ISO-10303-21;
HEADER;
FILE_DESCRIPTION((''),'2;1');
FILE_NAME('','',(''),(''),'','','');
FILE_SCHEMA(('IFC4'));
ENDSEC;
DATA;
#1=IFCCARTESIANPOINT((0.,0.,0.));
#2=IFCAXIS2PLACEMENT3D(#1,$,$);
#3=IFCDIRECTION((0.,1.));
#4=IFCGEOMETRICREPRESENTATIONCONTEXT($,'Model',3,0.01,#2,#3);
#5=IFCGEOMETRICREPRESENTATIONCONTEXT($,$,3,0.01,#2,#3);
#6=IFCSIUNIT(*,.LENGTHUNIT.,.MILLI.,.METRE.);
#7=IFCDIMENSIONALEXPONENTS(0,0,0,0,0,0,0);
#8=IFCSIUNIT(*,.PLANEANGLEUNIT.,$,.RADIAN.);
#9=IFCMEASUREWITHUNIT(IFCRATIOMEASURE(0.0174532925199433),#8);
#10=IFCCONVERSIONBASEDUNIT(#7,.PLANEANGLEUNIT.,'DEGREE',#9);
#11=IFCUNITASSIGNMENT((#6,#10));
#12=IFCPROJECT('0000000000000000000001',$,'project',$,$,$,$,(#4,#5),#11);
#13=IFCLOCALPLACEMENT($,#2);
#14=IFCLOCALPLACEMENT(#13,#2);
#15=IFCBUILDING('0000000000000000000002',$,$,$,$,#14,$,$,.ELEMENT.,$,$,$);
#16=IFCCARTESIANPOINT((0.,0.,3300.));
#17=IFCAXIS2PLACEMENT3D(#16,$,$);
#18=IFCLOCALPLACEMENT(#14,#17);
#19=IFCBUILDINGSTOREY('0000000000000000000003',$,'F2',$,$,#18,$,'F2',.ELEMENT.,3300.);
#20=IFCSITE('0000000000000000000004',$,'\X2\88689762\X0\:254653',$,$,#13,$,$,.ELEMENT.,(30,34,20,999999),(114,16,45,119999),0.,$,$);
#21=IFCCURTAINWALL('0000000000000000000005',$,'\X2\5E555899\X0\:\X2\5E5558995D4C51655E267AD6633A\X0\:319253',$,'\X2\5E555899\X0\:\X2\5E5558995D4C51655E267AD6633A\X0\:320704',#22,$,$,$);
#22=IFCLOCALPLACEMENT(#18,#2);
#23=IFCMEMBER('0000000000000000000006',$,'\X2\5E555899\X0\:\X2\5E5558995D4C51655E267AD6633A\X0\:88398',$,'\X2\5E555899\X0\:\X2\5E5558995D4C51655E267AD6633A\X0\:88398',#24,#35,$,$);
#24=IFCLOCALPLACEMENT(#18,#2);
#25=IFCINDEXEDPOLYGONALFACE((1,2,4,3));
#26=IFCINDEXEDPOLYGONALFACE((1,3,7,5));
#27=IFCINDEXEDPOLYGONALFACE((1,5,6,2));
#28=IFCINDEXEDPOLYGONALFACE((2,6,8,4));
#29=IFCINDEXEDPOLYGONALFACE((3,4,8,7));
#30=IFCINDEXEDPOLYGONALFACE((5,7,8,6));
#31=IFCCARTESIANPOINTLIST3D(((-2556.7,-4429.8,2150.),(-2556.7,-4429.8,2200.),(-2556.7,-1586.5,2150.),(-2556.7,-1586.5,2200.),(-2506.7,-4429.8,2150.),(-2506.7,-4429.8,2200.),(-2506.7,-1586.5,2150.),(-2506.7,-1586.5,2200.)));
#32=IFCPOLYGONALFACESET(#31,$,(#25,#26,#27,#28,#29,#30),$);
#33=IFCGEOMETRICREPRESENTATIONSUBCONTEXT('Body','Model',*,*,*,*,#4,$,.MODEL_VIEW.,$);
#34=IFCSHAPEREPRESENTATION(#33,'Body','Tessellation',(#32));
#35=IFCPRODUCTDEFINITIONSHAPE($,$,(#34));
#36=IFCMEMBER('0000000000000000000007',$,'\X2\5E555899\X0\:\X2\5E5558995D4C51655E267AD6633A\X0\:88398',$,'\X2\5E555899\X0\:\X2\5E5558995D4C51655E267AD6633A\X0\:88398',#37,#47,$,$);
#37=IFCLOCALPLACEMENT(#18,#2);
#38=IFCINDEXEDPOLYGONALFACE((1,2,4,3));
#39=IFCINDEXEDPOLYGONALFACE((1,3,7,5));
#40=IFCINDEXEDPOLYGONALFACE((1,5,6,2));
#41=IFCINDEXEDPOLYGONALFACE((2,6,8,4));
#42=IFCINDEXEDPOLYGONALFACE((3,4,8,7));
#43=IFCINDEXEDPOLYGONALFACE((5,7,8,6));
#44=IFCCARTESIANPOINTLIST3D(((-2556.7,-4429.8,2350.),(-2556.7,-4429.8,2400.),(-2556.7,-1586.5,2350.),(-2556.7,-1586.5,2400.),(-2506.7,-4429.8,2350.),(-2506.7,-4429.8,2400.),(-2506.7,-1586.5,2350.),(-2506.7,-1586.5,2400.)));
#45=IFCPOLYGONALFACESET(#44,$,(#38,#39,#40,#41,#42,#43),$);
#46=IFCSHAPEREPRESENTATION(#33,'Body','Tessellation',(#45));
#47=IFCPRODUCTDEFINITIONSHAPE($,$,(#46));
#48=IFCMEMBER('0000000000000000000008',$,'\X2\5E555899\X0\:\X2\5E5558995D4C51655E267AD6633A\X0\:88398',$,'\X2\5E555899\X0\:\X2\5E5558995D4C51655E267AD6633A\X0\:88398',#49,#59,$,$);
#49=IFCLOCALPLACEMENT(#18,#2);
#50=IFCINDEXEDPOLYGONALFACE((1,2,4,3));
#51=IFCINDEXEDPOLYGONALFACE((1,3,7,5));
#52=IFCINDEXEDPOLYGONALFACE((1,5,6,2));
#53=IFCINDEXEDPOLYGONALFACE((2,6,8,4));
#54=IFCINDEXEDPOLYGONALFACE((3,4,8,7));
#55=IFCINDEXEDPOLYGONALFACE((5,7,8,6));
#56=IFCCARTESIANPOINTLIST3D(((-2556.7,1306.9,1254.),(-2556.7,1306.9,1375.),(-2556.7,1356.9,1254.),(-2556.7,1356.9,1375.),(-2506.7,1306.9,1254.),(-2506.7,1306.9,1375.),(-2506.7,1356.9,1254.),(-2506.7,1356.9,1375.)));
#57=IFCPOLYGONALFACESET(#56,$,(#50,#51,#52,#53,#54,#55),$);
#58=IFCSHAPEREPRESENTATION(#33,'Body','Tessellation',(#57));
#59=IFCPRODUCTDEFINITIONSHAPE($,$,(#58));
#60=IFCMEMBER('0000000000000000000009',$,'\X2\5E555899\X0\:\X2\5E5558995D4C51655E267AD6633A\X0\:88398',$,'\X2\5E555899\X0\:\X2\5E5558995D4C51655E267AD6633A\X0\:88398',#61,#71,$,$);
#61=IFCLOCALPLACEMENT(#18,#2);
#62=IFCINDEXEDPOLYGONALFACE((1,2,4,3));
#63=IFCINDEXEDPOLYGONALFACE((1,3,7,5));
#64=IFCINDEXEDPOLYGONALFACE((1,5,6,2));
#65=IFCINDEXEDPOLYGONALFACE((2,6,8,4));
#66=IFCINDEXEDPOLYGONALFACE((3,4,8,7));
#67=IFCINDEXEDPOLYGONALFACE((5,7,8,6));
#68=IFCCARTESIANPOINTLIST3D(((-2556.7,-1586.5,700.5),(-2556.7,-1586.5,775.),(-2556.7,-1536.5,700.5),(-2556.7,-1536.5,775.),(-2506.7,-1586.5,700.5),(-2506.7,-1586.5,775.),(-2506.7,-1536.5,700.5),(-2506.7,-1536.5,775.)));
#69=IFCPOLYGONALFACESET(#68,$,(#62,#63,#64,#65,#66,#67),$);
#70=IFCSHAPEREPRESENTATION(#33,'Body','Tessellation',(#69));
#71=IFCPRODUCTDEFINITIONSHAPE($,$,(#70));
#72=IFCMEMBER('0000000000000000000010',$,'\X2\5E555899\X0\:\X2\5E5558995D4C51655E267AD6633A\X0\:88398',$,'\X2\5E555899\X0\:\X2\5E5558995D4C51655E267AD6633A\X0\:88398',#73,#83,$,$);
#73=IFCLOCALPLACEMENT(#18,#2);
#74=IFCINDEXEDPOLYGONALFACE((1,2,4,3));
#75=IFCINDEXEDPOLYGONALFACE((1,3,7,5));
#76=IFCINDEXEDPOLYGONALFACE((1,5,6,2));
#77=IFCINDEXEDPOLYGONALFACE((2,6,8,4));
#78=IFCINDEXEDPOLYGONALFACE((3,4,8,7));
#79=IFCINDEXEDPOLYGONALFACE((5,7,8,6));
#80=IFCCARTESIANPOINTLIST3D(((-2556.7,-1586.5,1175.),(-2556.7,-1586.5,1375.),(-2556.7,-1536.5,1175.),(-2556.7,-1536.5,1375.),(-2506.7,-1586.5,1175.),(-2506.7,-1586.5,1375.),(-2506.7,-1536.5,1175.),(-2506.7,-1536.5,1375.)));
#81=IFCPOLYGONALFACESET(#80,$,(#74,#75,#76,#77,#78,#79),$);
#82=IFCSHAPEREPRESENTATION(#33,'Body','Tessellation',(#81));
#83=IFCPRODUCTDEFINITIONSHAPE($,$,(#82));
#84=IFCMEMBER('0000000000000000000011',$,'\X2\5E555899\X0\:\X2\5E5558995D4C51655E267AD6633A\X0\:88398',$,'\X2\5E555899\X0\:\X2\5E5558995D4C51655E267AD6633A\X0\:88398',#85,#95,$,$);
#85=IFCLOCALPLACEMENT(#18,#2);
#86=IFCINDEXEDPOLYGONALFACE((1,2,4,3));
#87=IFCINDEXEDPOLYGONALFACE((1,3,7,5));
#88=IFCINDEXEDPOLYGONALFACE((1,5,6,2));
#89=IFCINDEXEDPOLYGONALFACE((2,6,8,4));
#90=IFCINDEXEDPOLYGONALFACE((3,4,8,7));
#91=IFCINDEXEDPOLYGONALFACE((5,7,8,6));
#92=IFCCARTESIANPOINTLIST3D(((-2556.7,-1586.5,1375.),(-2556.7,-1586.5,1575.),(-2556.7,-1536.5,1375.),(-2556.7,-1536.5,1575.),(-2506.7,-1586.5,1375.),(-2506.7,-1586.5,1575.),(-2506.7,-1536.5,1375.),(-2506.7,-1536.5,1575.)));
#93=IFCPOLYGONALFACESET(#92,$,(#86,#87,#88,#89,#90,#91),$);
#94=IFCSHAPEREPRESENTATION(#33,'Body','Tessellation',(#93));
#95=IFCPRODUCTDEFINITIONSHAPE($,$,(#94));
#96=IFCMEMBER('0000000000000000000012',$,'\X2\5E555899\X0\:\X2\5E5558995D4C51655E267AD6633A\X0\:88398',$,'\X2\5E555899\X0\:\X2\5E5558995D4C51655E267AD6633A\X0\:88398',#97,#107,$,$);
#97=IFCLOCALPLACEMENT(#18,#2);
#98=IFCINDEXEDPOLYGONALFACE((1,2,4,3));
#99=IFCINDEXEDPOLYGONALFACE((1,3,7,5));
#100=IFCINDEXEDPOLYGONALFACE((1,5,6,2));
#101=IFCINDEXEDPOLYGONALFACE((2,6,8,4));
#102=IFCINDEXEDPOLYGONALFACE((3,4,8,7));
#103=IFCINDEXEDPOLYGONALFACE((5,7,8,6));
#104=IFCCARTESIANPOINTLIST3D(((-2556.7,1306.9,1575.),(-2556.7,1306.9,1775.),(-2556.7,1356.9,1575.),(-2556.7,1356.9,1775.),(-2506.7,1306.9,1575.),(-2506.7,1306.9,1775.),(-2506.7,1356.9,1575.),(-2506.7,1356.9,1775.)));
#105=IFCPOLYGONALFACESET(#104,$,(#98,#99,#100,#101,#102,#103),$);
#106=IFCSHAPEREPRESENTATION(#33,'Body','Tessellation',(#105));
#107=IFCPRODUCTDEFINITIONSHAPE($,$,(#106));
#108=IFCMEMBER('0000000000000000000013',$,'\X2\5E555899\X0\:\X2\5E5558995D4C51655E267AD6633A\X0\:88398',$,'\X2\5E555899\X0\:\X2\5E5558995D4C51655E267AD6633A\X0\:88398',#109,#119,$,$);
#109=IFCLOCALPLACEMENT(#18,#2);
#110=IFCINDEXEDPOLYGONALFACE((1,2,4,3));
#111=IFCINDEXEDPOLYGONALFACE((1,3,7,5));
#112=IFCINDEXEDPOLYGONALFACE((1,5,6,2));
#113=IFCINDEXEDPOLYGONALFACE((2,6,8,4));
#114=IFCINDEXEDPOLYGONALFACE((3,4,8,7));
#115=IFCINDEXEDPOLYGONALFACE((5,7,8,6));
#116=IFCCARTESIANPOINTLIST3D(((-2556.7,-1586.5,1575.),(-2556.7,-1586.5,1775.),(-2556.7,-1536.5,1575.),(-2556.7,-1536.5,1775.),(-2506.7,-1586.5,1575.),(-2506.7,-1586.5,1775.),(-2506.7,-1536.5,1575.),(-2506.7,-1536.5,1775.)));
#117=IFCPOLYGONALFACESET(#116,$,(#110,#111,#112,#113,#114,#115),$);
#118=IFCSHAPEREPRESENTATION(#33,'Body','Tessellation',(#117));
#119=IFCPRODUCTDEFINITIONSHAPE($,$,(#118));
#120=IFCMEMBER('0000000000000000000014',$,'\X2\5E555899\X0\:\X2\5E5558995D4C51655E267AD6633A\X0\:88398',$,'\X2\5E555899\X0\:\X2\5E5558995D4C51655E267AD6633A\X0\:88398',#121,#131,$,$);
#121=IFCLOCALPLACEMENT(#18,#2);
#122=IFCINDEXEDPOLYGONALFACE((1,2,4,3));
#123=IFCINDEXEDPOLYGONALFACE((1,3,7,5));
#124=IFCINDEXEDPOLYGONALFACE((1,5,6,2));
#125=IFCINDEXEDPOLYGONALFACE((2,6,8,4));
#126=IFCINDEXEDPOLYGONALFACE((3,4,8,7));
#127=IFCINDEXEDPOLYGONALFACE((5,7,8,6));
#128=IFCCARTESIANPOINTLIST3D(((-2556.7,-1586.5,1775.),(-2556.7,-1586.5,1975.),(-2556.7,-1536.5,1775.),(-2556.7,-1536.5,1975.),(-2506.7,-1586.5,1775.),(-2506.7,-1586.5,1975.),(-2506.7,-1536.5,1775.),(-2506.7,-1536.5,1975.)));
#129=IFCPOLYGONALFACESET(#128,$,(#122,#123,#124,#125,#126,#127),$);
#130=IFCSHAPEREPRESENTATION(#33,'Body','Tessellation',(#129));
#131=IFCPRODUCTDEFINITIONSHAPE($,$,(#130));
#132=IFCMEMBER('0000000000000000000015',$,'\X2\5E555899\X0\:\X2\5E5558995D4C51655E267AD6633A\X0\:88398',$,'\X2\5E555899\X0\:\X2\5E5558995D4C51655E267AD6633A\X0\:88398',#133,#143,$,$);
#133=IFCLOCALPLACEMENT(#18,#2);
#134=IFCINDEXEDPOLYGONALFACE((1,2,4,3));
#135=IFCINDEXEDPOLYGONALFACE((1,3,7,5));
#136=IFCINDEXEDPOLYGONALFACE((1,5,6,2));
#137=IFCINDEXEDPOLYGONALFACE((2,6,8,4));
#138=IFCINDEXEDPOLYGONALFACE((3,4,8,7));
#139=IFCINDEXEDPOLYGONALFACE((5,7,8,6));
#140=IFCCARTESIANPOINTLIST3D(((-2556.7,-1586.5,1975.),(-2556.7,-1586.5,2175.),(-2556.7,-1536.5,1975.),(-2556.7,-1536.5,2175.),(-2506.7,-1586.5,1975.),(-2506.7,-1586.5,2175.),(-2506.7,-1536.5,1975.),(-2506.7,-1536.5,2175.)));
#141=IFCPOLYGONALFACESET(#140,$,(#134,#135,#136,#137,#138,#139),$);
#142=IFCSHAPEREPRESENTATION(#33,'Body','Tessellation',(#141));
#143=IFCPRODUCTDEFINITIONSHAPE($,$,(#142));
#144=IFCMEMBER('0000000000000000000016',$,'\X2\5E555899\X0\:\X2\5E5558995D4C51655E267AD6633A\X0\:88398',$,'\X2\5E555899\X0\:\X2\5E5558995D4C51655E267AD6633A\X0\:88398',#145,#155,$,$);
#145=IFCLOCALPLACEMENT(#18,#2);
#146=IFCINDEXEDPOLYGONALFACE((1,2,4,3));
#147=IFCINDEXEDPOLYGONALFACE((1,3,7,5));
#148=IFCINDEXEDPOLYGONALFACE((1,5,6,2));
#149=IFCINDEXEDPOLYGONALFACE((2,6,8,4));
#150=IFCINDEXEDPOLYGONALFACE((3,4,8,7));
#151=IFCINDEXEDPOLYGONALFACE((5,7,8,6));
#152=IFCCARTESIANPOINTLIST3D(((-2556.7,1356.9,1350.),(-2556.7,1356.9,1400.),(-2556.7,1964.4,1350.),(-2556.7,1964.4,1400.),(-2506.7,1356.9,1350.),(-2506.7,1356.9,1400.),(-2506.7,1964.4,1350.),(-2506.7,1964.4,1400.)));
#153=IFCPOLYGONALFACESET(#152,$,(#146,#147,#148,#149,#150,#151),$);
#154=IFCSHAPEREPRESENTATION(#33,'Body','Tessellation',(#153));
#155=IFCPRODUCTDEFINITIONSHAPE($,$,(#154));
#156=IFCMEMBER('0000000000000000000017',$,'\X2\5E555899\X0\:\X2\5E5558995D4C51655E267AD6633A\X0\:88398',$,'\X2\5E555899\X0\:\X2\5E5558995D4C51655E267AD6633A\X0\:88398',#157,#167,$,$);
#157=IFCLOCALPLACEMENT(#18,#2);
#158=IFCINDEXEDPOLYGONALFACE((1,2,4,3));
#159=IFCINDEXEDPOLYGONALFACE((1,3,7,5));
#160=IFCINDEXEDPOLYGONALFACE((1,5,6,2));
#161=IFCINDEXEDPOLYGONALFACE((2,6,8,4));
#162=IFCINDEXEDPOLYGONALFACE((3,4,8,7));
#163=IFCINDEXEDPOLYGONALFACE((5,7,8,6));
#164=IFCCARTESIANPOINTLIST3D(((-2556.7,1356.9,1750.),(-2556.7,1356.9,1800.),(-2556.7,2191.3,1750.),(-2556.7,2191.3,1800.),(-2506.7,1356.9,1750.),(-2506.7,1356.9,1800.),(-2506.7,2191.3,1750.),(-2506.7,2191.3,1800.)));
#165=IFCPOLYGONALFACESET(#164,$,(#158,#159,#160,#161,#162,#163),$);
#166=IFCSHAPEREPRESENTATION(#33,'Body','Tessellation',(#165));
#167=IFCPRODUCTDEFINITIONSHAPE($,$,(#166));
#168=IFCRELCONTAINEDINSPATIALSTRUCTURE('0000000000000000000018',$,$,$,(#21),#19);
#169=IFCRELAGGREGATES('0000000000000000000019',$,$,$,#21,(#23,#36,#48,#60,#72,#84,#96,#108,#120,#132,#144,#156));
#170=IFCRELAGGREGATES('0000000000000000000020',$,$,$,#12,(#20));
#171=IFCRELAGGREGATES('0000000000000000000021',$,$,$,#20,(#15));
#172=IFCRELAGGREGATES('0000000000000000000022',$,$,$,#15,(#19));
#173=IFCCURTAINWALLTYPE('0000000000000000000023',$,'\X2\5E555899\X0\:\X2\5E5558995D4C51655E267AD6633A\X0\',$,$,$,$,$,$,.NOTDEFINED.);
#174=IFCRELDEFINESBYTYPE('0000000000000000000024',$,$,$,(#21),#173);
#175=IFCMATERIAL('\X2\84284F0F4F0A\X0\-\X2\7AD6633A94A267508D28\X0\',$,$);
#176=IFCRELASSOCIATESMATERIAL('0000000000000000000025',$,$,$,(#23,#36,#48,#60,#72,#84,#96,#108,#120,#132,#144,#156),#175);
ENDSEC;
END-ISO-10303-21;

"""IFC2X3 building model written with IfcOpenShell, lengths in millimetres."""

from ifc_helpers import new_model, entity, si_unit, converted_unit, direction, frame, origin, origin_2d_with_axis, place, context, subcontext, project, spatial, rectangle, extrude, material, type_object, element, aggregate, save


model = new_model("IFC2X3")

# Units and contexts
model_context = context("Model", 3, precision=0.01, world=origin(), true_north=direction((0.0, 1.0)))
context_of_model = context(None, 3, precision=0.01, world=origin(), true_north=direction((0.0, 1.0)))
body_context = subcontext(model_context, "Body", "Model", "MODEL_VIEW")
ifc_project = project(units=[si_unit("LENGTHUNIT", "METRE", prefix="MILLI"), converted_unit("PLANEANGLEUNIT", "DEGREE", entity("IfcRatioMeasure", 0.0174532925199433), si_unit("PLANEANGLEUNIT", "RADIAN"), dimensions=[0, 0, 0, 0, 0, 0, 0])], contexts=[model_context, context_of_model])

# Site, building, storey
site_placement = place(None, origin())
site = spatial("IfcSite", under=ifc_project, at=site_placement, Name="表面:254653", CompositionType="ELEMENT", RefLatitude=(30, 34, 20, 999999), RefLongitude=(114, 16, 45, 119999), RefElevation=0.0)
building_placement = place(site_placement, origin())
building = spatial("IfcBuilding", under=site, at=building_placement, CompositionType="ELEMENT")
storey_placement = place(building_placement, frame((0.0, 0.0, 3300.0)))
storey = spatial("IfcBuildingStorey", under=building, at=storey_placement, Name="F2", LongName="F2", CompositionType="ELEMENT", Elevation=3300.0)

# Curtain wall, members
curtain_wall_type_1 = type_object("IfcCurtainWallType", Name="幕墙:幕墙嵌入带竖挺", PredefinedType="NOTDEFINED")
curtain_wall_1_placement = place(storey_placement, frame((0.0, 0.0, -3300.0)))
curtain_wall_1 = element("IfcCurtainWall", 1, at=curtain_wall_1_placement, inside=storey, type_object=curtain_wall_type_1, Name="幕墙:幕墙嵌入带竖挺:319253", ObjectType="幕墙:幕墙嵌入带竖挺:320704")
ifc_material_1 = material(Name="萨伏伊-竖挺钢材质")
member_1_placement = place(curtain_wall_1_placement, frame((0.0, 0.0, 3300.0)))
member_1 = element("IfcMember", 2, at=member_1_placement, material=ifc_material_1, Name="幕墙:幕墙嵌入带竖挺:88398", ObjectType="幕墙:幕墙嵌入带竖挺:88398", context=body_context, shape_type="SweptSolid", body=[
    extrude(rectangle(XDim=50.0, YDim=50.0, at=origin_2d_with_axis()), frame((-2531.7, -4429.8, 2175.0), z_axis=(0.0, 1.0, 0.0), x_axis=(0.0, 0.0, -1.0)), (0.0, 0.0, 1.0), 2843.3),
])
member_2_placement = place(curtain_wall_1_placement, frame((0.0, 0.0, 3300.0)))
member_2 = element("IfcMember", 3, at=member_2_placement, material=ifc_material_1, Name="幕墙:幕墙嵌入带竖挺:88398", ObjectType="幕墙:幕墙嵌入带竖挺:88398", context=body_context, shape_type="SweptSolid", body=[
    extrude(rectangle(XDim=50.0, YDim=50.0, at=origin_2d_with_axis()), frame((-2531.7, -4429.8, 2375.0), z_axis=(0.0, 1.0, 0.0), x_axis=(0.0, 0.0, -1.0)), (0.0, 0.0, 1.0), 2843.3),
])
member_3_placement = place(curtain_wall_1_placement, frame((0.0, 0.0, 3300.0)))
member_3 = element("IfcMember", 4, at=member_3_placement, material=ifc_material_1, Name="幕墙:幕墙嵌入带竖挺:88398", ObjectType="幕墙:幕墙嵌入带竖挺:88398", context=body_context, shape_type="SweptSolid", body=[
    extrude(rectangle(XDim=50.0, YDim=50.0, at=origin_2d_with_axis()), frame((-2531.7, 1331.9, 1254.0), z_axis=(0.0, 0.0, 1.0), x_axis=(-1.0, 0.0, 0.0)), (0.0, 0.0, 1.0), 121.0),
])
member_4_placement = place(curtain_wall_1_placement, frame((0.0, 0.0, 3300.0)))
member_4 = element("IfcMember", 5, at=member_4_placement, material=ifc_material_1, Name="幕墙:幕墙嵌入带竖挺:88398", ObjectType="幕墙:幕墙嵌入带竖挺:88398", context=body_context, shape_type="SweptSolid", body=[
    extrude(rectangle(XDim=50.0, YDim=50.0, at=origin_2d_with_axis()), frame((-2531.7, -1561.5, 700.5), z_axis=(0.0, 0.0, 1.0), x_axis=(-1.0, 0.0, 0.0)), (0.0, 0.0, 1.0), 74.5),
])
member_5_placement = place(curtain_wall_1_placement, frame((0.0, 0.0, 3300.0)))
member_5 = element("IfcMember", 6, at=member_5_placement, material=ifc_material_1, Name="幕墙:幕墙嵌入带竖挺:88398", ObjectType="幕墙:幕墙嵌入带竖挺:88398", context=body_context, shape_type="SweptSolid", body=[
    extrude(rectangle(XDim=50.0, YDim=50.0, at=origin_2d_with_axis()), frame((-2531.7, -1561.5, 1175.0), z_axis=(0.0, 0.0, 1.0), x_axis=(-1.0, 0.0, 0.0)), (0.0, 0.0, 1.0), 200.0),
])
member_6_placement = place(curtain_wall_1_placement, frame((0.0, 0.0, 3300.0)))
member_6 = element("IfcMember", 7, at=member_6_placement, material=ifc_material_1, Name="幕墙:幕墙嵌入带竖挺:88398", ObjectType="幕墙:幕墙嵌入带竖挺:88398", context=body_context, shape_type="SweptSolid", body=[
    extrude(rectangle(XDim=50.0, YDim=50.0, at=origin_2d_with_axis()), frame((-2531.7, -1561.5, 1375.0), z_axis=(0.0, 0.0, 1.0), x_axis=(-1.0, 0.0, 0.0)), (0.0, 0.0, 1.0), 200.0),
])
member_7_placement = place(curtain_wall_1_placement, frame((0.0, 0.0, 3300.0)))
member_7 = element("IfcMember", 8, at=member_7_placement, material=ifc_material_1, Name="幕墙:幕墙嵌入带竖挺:88398", ObjectType="幕墙:幕墙嵌入带竖挺:88398", context=body_context, shape_type="SweptSolid", body=[
    extrude(rectangle(XDim=50.0, YDim=50.0, at=origin_2d_with_axis()), frame((-2531.7, 1331.9, 1575.0), z_axis=(0.0, 0.0, 1.0), x_axis=(-1.0, 0.0, 0.0)), (0.0, 0.0, 1.0), 200.0),
])
member_8_placement = place(curtain_wall_1_placement, frame((0.0, 0.0, 3300.0)))
member_8 = element("IfcMember", 9, at=member_8_placement, material=ifc_material_1, Name="幕墙:幕墙嵌入带竖挺:88398", ObjectType="幕墙:幕墙嵌入带竖挺:88398", context=body_context, shape_type="SweptSolid", body=[
    extrude(rectangle(XDim=50.0, YDim=50.0, at=origin_2d_with_axis()), frame((-2531.7, -1561.5, 1575.0), z_axis=(0.0, 0.0, 1.0), x_axis=(-1.0, 0.0, 0.0)), (0.0, 0.0, 1.0), 200.0),
])
member_9_placement = place(curtain_wall_1_placement, frame((0.0, 0.0, 3300.0)))
member_9 = element("IfcMember", 10, at=member_9_placement, material=ifc_material_1, Name="幕墙:幕墙嵌入带竖挺:88398", ObjectType="幕墙:幕墙嵌入带竖挺:88398", context=body_context, shape_type="SweptSolid", body=[
    extrude(rectangle(XDim=50.0, YDim=50.0, at=origin_2d_with_axis()), frame((-2531.7, -1561.5, 1775.0), z_axis=(0.0, 0.0, 1.0), x_axis=(-1.0, 0.0, 0.0)), (0.0, 0.0, 1.0), 200.0),
])
member_10_placement = place(curtain_wall_1_placement, frame((0.0, 0.0, 3300.0)))
member_10 = element("IfcMember", 11, at=member_10_placement, material=ifc_material_1, Name="幕墙:幕墙嵌入带竖挺:88398", ObjectType="幕墙:幕墙嵌入带竖挺:88398", context=body_context, shape_type="SweptSolid", body=[
    extrude(rectangle(XDim=50.0, YDim=50.0, at=origin_2d_with_axis()), frame((-2531.7, -1561.5, 1975.0), z_axis=(0.0, 0.0, 1.0), x_axis=(-1.0, 0.0, 0.0)), (0.0, 0.0, 1.0), 200.0),
])
member_11_placement = place(curtain_wall_1_placement, frame((0.0, 0.0, 3300.0)))
member_11 = element("IfcMember", 12, at=member_11_placement, material=ifc_material_1, Name="幕墙:幕墙嵌入带竖挺:88398", ObjectType="幕墙:幕墙嵌入带竖挺:88398", context=body_context, shape_type="SweptSolid", body=[
    extrude(rectangle(XDim=50.0, YDim=50.0, at=origin_2d_with_axis()), frame((-2531.7, 1356.9, 1375.0), z_axis=(0.0, 1.0, 0.0), x_axis=(0.0, 0.0, -1.0)), (0.0, 0.0, 1.0), 607.5),
])
member_12_placement = place(curtain_wall_1_placement, frame((0.0, 0.0, 3300.0)))
member_12 = element("IfcMember", 13, at=member_12_placement, material=ifc_material_1, Name="幕墙:幕墙嵌入带竖挺:88398", ObjectType="幕墙:幕墙嵌入带竖挺:88398", context=body_context, shape_type="SweptSolid", body=[
    extrude(rectangle(XDim=50.0, YDim=50.0, at=origin_2d_with_axis()), frame((-2531.7, 1356.9, 1775.0), z_axis=(0.0, 1.0, 0.0), x_axis=(0.0, 0.0, -1.0)), (0.0, 0.0, 1.0), 834.4),
])
aggregate(curtain_wall_1, [member_1, member_2, member_3, member_4, member_5, member_6, member_7, member_8, member_9, member_10, member_11, member_12])

save(model, "model.ifc")
